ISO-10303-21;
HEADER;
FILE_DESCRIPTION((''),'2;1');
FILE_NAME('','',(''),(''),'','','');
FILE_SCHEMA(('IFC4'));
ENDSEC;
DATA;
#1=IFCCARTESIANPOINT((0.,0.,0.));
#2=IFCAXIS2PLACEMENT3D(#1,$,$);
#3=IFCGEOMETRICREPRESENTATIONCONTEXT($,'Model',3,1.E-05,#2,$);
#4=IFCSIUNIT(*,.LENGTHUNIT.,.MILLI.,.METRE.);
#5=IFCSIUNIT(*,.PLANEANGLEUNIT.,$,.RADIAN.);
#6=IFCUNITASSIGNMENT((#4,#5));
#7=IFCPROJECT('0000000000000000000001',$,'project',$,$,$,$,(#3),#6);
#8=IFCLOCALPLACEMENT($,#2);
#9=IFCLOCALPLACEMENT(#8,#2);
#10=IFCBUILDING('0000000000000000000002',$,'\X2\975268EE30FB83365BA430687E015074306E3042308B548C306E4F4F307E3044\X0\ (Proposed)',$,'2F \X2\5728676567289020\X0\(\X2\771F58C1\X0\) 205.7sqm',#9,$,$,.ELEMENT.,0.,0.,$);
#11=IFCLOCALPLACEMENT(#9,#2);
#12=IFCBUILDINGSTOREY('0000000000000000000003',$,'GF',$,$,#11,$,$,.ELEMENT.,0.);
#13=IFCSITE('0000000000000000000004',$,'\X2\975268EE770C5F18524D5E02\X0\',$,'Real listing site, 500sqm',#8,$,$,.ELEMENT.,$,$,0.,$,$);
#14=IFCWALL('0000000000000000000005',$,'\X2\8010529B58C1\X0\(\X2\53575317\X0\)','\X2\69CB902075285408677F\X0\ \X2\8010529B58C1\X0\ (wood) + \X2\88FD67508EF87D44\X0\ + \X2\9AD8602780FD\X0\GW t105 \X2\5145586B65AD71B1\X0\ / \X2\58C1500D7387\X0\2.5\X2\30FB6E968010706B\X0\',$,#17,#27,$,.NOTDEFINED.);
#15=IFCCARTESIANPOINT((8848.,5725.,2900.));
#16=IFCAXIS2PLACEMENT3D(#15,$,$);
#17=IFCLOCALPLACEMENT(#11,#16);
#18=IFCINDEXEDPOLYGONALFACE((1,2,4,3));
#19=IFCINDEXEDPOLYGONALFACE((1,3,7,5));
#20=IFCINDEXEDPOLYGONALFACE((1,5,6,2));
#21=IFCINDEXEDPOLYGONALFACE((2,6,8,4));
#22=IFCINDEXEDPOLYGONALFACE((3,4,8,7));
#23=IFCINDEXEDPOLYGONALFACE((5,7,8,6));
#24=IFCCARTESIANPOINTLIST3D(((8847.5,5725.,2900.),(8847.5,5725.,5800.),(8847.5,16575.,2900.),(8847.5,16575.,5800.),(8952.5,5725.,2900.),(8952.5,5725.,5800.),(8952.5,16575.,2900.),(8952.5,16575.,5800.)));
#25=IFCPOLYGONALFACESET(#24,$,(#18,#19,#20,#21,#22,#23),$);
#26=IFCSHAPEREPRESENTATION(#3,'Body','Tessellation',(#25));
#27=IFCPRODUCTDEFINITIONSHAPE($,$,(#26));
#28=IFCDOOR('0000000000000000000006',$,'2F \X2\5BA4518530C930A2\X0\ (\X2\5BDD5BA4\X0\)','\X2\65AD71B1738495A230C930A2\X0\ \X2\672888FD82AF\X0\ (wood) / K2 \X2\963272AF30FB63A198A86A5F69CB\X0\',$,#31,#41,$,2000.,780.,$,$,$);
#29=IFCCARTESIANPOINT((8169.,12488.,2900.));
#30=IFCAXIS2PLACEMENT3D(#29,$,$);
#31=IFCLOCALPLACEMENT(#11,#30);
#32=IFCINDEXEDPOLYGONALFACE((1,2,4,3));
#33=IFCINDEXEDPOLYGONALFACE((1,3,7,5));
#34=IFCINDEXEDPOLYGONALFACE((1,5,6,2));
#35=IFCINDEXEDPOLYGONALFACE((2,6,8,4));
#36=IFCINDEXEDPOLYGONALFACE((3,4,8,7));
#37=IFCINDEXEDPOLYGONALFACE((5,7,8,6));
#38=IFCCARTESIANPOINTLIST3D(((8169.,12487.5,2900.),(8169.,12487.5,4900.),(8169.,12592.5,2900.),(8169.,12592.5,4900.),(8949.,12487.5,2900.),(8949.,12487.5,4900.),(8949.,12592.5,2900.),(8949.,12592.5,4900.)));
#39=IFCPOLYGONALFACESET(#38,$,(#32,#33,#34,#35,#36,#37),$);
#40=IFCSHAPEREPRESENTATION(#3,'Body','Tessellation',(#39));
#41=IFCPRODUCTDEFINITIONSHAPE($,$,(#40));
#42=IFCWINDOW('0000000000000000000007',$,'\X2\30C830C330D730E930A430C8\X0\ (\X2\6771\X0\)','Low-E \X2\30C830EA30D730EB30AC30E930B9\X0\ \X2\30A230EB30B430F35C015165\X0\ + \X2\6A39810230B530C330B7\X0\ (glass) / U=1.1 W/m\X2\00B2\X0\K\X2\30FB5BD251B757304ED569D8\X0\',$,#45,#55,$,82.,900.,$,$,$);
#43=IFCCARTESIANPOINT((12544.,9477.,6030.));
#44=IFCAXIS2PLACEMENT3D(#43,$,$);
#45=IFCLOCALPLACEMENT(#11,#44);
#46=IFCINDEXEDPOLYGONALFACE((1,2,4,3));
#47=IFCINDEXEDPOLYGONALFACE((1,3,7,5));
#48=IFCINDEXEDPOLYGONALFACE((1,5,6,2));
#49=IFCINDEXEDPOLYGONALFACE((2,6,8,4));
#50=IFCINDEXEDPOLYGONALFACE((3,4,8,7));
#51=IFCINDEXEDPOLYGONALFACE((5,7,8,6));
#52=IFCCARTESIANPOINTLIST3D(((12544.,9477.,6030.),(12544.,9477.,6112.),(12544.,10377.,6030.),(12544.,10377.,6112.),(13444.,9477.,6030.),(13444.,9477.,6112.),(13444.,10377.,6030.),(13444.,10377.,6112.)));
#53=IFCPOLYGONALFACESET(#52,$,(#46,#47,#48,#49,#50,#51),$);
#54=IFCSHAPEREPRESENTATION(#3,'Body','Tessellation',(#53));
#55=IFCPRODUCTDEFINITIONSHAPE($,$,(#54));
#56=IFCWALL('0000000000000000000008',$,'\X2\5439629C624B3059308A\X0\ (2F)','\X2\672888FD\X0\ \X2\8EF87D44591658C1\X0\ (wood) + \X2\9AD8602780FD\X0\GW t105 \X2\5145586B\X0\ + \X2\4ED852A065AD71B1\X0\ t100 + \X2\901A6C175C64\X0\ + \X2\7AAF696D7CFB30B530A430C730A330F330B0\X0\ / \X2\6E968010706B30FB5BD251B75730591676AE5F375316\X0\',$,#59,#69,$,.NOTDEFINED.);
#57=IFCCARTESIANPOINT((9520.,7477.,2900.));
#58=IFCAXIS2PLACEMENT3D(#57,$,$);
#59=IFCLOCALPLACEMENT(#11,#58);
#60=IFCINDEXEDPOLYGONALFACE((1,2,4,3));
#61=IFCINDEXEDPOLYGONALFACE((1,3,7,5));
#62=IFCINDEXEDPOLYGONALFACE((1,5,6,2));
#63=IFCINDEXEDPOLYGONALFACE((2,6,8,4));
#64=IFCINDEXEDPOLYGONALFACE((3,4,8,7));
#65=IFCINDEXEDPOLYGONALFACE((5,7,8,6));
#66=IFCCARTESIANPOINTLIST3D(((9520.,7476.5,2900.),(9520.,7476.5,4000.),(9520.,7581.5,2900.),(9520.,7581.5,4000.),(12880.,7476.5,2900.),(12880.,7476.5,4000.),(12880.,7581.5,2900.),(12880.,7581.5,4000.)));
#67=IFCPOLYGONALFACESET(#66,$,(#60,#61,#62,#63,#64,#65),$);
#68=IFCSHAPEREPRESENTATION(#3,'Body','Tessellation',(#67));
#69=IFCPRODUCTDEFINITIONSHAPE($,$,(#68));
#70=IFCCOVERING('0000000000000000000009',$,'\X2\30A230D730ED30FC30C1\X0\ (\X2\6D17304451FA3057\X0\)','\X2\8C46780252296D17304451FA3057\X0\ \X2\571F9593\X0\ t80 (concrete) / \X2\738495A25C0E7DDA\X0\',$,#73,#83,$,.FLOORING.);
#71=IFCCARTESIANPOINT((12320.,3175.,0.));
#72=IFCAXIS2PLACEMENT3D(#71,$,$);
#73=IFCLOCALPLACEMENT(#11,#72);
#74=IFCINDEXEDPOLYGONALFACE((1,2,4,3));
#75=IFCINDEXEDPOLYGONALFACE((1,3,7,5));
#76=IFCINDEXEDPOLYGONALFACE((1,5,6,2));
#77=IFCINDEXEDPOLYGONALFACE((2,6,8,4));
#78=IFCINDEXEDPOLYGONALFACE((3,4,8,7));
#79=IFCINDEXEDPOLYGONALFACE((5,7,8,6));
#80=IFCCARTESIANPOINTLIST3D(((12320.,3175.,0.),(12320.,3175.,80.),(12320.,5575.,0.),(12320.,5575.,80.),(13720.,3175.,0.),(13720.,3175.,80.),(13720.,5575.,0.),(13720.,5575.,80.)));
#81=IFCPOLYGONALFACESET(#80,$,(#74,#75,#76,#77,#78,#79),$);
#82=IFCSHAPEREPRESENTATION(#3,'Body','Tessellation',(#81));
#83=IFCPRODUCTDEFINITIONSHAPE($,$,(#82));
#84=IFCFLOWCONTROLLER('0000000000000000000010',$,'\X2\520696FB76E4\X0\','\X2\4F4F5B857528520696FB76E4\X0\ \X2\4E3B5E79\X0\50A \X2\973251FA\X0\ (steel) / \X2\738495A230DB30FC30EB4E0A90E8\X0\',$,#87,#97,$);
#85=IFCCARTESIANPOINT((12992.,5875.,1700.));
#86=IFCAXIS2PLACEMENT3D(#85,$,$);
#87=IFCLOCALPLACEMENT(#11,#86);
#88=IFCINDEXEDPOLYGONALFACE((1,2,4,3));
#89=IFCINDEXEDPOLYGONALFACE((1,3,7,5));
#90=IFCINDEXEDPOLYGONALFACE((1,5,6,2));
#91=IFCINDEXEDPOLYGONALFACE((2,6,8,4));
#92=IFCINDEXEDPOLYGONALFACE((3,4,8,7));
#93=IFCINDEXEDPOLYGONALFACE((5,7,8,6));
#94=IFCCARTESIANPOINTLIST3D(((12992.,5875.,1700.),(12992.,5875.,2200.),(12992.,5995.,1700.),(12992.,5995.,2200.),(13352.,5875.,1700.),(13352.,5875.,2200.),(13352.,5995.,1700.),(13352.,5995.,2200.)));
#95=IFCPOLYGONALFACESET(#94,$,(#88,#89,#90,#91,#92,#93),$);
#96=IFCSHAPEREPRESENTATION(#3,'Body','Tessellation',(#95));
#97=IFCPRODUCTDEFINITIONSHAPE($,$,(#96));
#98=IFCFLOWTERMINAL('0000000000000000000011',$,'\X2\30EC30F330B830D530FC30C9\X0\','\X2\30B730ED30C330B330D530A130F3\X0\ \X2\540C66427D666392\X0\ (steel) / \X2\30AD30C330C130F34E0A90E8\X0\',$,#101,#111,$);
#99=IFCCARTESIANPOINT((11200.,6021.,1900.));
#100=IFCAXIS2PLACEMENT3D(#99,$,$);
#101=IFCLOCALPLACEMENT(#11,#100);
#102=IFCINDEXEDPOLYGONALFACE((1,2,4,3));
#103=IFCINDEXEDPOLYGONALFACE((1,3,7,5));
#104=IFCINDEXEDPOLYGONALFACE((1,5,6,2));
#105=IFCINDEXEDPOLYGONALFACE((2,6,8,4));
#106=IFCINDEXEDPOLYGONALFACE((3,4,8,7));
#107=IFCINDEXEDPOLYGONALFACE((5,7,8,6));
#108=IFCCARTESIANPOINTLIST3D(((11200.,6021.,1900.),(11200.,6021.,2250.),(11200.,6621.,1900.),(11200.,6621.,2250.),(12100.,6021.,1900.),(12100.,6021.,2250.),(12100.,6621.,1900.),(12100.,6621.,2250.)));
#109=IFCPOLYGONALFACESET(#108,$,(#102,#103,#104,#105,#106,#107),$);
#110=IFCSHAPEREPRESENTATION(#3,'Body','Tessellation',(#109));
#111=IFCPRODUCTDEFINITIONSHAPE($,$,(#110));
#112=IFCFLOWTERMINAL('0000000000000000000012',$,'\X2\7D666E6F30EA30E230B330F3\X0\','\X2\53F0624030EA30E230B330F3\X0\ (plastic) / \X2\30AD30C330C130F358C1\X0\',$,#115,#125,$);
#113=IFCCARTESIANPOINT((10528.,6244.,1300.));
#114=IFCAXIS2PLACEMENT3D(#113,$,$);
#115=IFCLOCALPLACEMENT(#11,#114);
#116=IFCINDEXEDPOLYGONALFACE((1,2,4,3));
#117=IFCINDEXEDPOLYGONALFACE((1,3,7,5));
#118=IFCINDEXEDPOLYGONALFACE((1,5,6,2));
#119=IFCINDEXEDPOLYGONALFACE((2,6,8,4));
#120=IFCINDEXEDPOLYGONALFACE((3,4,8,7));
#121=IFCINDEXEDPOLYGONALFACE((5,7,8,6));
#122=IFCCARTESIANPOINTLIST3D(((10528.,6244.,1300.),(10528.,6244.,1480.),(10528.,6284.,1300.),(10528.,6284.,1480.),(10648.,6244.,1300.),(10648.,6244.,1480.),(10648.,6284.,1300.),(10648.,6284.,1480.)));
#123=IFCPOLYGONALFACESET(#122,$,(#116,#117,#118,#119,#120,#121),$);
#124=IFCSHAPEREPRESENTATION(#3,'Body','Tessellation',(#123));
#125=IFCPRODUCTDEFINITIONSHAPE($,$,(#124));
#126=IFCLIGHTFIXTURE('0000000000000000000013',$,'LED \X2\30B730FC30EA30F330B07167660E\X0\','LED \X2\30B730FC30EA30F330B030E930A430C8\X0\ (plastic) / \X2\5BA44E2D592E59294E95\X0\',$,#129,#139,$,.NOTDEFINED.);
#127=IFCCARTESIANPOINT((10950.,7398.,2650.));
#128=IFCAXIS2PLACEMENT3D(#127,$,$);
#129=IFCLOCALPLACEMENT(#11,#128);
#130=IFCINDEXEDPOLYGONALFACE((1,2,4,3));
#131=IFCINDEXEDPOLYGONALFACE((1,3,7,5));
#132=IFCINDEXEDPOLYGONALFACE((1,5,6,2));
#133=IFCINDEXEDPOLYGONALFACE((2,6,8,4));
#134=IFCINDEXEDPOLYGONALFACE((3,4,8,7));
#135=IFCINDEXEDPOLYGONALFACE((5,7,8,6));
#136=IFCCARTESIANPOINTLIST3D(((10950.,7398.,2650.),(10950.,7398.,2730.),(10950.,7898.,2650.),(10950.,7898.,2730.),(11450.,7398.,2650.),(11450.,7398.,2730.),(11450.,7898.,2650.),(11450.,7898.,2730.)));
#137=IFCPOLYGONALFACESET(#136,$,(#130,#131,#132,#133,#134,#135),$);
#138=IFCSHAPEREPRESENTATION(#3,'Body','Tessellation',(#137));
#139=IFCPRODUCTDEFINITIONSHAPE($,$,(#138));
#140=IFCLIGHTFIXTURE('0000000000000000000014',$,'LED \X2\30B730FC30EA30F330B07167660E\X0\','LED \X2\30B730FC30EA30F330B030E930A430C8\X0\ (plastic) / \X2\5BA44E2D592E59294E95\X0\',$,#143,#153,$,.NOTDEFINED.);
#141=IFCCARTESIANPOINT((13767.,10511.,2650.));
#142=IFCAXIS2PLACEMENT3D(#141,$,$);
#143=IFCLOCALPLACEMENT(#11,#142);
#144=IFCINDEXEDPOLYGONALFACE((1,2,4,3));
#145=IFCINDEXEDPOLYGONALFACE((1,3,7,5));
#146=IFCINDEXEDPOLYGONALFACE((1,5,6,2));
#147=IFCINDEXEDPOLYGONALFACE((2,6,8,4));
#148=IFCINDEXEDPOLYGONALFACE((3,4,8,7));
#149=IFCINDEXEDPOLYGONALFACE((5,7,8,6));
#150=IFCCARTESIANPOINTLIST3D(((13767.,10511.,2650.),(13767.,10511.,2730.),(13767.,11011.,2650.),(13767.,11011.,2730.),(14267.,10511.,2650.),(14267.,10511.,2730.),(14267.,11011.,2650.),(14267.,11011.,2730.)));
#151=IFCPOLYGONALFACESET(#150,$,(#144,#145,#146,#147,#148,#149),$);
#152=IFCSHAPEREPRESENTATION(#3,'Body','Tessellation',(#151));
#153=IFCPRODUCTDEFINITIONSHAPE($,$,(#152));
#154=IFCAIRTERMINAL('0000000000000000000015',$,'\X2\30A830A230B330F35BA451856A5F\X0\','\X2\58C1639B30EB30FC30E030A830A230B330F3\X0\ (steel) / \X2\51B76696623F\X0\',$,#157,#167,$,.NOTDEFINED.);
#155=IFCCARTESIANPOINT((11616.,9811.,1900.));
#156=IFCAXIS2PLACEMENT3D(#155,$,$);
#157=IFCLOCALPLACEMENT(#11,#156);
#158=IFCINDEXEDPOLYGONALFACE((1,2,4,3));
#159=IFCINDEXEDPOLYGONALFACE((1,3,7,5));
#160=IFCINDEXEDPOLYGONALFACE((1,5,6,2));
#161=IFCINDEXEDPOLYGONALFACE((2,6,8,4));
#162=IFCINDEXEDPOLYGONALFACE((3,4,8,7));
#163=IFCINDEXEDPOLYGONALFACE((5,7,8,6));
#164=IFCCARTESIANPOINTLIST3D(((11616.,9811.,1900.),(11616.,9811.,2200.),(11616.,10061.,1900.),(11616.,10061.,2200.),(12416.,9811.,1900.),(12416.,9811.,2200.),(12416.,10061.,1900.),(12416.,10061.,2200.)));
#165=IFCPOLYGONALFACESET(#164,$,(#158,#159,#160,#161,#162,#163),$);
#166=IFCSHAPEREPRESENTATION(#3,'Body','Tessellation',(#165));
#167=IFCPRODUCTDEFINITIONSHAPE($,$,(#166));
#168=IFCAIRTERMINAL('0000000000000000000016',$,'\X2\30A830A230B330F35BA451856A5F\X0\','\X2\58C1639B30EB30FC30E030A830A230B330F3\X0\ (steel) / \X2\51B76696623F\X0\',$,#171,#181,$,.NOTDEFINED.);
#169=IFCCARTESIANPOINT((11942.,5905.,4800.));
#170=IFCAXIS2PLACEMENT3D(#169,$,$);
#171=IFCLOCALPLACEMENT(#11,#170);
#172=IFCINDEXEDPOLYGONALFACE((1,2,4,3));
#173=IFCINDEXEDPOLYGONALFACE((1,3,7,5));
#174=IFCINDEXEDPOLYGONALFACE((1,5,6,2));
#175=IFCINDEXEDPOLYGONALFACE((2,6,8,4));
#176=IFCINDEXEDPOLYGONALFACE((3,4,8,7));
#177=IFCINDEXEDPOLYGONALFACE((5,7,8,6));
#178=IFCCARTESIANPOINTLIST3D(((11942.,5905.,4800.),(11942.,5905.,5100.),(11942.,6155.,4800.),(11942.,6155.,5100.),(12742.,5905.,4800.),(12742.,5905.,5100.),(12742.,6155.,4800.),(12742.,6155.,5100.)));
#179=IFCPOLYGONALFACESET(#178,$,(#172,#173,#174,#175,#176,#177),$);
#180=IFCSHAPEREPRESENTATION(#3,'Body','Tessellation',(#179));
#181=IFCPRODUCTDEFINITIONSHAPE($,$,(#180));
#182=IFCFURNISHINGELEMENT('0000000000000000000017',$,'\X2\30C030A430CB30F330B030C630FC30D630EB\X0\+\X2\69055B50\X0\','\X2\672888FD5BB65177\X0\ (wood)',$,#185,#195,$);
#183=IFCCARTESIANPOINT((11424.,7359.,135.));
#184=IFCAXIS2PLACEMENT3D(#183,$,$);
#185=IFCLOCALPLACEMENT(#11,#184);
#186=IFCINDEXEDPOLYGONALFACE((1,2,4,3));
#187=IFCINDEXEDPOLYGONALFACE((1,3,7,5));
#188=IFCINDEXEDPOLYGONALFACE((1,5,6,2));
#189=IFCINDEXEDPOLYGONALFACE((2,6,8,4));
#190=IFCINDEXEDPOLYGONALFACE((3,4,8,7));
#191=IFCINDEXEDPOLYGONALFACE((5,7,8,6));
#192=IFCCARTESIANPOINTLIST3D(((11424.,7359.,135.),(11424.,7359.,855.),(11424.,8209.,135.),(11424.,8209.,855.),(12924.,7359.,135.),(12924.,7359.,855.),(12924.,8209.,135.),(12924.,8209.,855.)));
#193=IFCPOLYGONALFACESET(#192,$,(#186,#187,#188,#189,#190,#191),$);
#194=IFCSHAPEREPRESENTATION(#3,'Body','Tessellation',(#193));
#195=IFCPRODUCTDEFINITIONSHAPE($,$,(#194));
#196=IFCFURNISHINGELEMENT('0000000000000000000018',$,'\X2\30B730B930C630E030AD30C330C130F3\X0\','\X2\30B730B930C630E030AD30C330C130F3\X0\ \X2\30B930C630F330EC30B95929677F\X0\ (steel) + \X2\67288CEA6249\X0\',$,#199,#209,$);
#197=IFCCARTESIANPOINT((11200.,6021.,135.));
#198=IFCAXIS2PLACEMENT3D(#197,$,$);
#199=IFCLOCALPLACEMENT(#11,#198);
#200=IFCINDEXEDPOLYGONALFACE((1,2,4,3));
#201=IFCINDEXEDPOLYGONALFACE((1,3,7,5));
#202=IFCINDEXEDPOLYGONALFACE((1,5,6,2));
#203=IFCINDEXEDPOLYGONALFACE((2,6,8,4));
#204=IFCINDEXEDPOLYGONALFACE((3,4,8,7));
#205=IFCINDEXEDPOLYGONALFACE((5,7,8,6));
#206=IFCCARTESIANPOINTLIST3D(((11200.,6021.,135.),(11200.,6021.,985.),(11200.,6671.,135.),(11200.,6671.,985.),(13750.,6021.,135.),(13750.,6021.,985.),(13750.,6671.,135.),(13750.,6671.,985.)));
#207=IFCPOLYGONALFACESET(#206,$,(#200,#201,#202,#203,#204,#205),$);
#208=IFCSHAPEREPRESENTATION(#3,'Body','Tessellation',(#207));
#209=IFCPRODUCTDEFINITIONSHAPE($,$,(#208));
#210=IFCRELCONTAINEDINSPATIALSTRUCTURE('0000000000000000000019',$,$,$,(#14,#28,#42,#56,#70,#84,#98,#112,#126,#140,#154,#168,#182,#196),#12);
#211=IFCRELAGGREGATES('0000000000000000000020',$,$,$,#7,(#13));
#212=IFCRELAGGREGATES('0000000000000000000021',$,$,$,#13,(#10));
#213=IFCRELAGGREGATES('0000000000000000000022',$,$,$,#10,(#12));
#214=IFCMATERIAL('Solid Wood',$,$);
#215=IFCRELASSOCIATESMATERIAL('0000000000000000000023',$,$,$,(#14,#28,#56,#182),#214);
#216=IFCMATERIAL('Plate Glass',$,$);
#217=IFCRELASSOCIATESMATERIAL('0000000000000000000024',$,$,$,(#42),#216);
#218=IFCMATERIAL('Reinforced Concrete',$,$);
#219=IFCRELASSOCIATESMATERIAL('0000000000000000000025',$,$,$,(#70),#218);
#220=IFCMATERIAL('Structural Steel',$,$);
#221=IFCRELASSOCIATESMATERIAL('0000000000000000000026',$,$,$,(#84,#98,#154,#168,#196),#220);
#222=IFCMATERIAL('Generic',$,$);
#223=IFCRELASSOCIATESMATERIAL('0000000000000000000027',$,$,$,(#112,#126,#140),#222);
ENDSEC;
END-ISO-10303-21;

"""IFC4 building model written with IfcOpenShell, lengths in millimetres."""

from ifc_helpers import new_model, si_unit, frame, frame_2d, origin, place, context, project, spatial, rectangle, extrude, material, element, fill, save


model = new_model("IFC4")

# Units and contexts
model_context = context("Model", 3, precision=1e-05, world=origin())
ifc_project = project(units=[si_unit("LENGTHUNIT", "METRE", prefix="MILLI"), si_unit("PLANEANGLEUNIT", "RADIAN")], contexts=[model_context])

# Site, building, storey
site_placement = place(None, origin())
site = spatial("IfcSite", under=ifc_project, at=site_placement, Name="青森県弘前市", ObjectType="Real listing site, 500sqm", CompositionType="ELEMENT", RefElevation=0.0)
building_placement = place(site_placement, origin())
building = spatial("IfcBuilding", under=site, at=building_placement, Name="青森・茶室と縁側のある和の住まい (Proposed)", ObjectType="2F 在来木造(真壁) 205.7sqm", CompositionType="ELEMENT", ElevationOfRefHeight=0.0, ElevationOfTerrain=0.0)
storey_placement = place(building_placement, origin())
storey = spatial("IfcBuildingStorey", under=building, at=storey_placement, Name="GF", CompositionType="ELEMENT", Elevation=0.0)

# Shared definitions
ifc_material_1 = material(Name="Solid Wood")

# Wall, opening, door
wall_1_placement = place(storey_placement, frame((8848.0, 5725.0, 2900.0)))
wall_1 = element("IfcWall", 1, at=wall_1_placement, inside=storey, material=ifc_material_1, Name="耐力壁(南北)", Description="構造用合板 耐力壁 (wood) + 製材軸組 + 高性能GW t105 充填断熱 / 壁倍率2.5・準耐火", PredefinedType="NOTDEFINED", context=model_context, shape_type="SweptSolid", body=[
    extrude(rectangle(XDim=105.0, YDim=10850.0, at=frame_2d((52.0, 5425.0))), frame((8848.0, 5725.0, 2900.0)), (0.0, 0.0, 1.0), 2900.0),
])
opening_1_placement = place(storey_placement, frame((8169.0, 12488.0, 2900.0)))
opening_1 = element("IfcOpeningElement", 2, at=opening_1_placement, cuts=wall_1, PredefinedType="NOTDEFINED", context=model_context, shape_type="SweptSolid", body=[
    extrude(rectangle(XDim=780.0, YDim=105.0, at=frame_2d((390.0, 52.0))), frame((8169.0, 12488.0, 2900.0)), (0.0, 0.0, 1.0), 2000.0),
])
door_1_placement = place(storey_placement, frame((8169.0, 12488.0, 2900.0)))
door_1 = element("IfcDoor", 3, at=door_1_placement, inside=storey, material=ifc_material_1, Name="2F 室内ドア (寝室)", Description="断熱玄関ドア 木製芯 (wood) / K2 防犯・採風機構", OverallHeight=2000.0, OverallWidth=780.0, context=model_context, shape_type="SweptSolid", body=[
    extrude(rectangle(XDim=780.0, YDim=105.0, at=frame_2d((390.0, 52.0))), frame((8169.0, 12488.0, 2900.0)), (0.0, 0.0, 1.0), 2000.0),
])
fill(opening_1, door_1)

# Window
ifc_material_2 = material(Name="Plate Glass")
window_placement = place(storey_placement, frame((12544.0, 9477.0, 6030.0)))
element("IfcWindow", 4, at=window_placement, inside=storey, material=ifc_material_2, Name="トップライト (東)", Description="Low-E トリプルガラス アルゴン封入 + 樹脂サッシ (glass) / U=1.1 W/m²K・寒冷地仕様", OverallHeight=82.0, OverallWidth=900.0, context=model_context, shape_type="SweptSolid", body=[
    extrude(rectangle(XDim=900.0, YDim=900.0, at=frame_2d((450.0, 450.0))), frame((12544.0, 9477.0, 6030.0)), (0.0, 0.0, 1.0), 82.0),
])

# Wall
wall_2_placement = place(storey_placement, frame((9520.0, 7477.0, 2900.0)))
element("IfcWall", 5, at=wall_2_placement, inside=storey, material=ifc_material_1, Name="吹抜手すり (2F)", Description="木製 軸組外壁 (wood) + 高性能GW t105 充填 + 付加断熱 t100 + 通気層 + 窯業系サイディング / 準耐火・寒冷地外皮強化", PredefinedType="NOTDEFINED", context=model_context, shape_type="SweptSolid", body=[
    extrude(rectangle(XDim=3360.0, YDim=105.0, at=frame_2d((1680.0, 52.0))), frame((9520.0, 7477.0, 2900.0)), (0.0, 0.0, 1.0), 1100.0),
])

# Covering
ifc_material_3 = material(Name="Reinforced Concrete")
covering_placement = place(storey_placement, frame((12320.0, 3175.0, 0.0)))
element("IfcCovering", 6, at=covering_placement, inside=storey, material=ifc_material_3, Name="アプローチ (洗い出し)", Description="豆砂利洗い出し 土間 t80 (concrete) / 玄関導線", PredefinedType="FLOORING", context=model_context, shape_type="SweptSolid", body=[
    extrude(rectangle(XDim=1400.0, YDim=2400.0, at=frame_2d((700.0, 1200.0))), frame((12320.0, 3175.0, 0.0)), (0.0, 0.0, 1.0), 80.0),
])

# Flow controller
ifc_material_4 = material(Name="Structural Steel")
flow_controller_placement = place(storey_placement, frame((12992.0, 5875.0, 1700.0)))
element("IfcFlowController", 7, at=flow_controller_placement, inside=storey, material=ifc_material_4, Name="分電盤", Description="住宅用分電盤 主幹50A 露出 (steel) / 玄関ホール上部", context=model_context, shape_type="SweptSolid", body=[
    extrude(rectangle(XDim=360.0, YDim=120.0, at=frame_2d((180.0, 60.0))), frame((12992.0, 5875.0, 1700.0)), (0.0, 0.0, 1.0), 500.0),
])

# Flow terminals
flow_terminal_1_placement = place(storey_placement, frame((11200.0, 6021.0, 1900.0)))
element("IfcFlowTerminal", 8, at=flow_terminal_1_placement, inside=storey, material=ifc_material_4, Name="レンジフード", Description="シロッコファン 同時給排 (steel) / キッチン上部", context=model_context, shape_type="SweptSolid", body=[
    extrude(rectangle(XDim=900.0, YDim=600.0, at=frame_2d((450.0, 300.0))), frame((11200.0, 6021.0, 1900.0)), (0.0, 0.0, 1.0), 350.0),
])
ifc_material_5 = material(Name="Generic")
flow_terminal_2_placement = place(storey_placement, frame((10528.0, 6244.0, 1300.0)))
element("IfcFlowTerminal", 9, at=flow_terminal_2_placement, inside=storey, material=ifc_material_5, Name="給湯リモコン", Description="台所リモコン (plastic) / キッチン壁", context=model_context, shape_type="SweptSolid", body=[
    extrude(rectangle(XDim=120.0, YDim=40.0, at=frame_2d((60.0, 20.0))), frame((10528.0, 6244.0, 1300.0)), (0.0, 0.0, 1.0), 180.0),
])

# Light fixtures
light_fixture_1_placement = place(storey_placement, frame((10950.0, 7398.0, 2650.0)))
element("IfcLightFixture", 10, at=light_fixture_1_placement, inside=storey, material=ifc_material_5, Name="LED シーリング照明", Description="LED シーリングライト (plastic) / 室中央天井", PredefinedType="NOTDEFINED", context=model_context, shape_type="SweptSolid", body=[
    extrude(rectangle(XDim=500.0, YDim=500.0, at=frame_2d((250.0, 250.0))), frame((10950.0, 7398.0, 2650.0)), (0.0, 0.0, 1.0), 80.0),
])
light_fixture_2_placement = place(storey_placement, frame((13767.0, 10511.0, 2650.0)))
element("IfcLightFixture", 11, at=light_fixture_2_placement, inside=storey, material=ifc_material_5, Name="LED シーリング照明", Description="LED シーリングライト (plastic) / 室中央天井", PredefinedType="NOTDEFINED", context=model_context, shape_type="SweptSolid", body=[
    extrude(rectangle(XDim=500.0, YDim=500.0, at=frame_2d((250.0, 250.0))), frame((13767.0, 10511.0, 2650.0)), (0.0, 0.0, 1.0), 80.0),
])

# Air terminals
air_terminal_1_placement = place(storey_placement, frame((11616.0, 9811.0, 1900.0)))
element("IfcAirTerminal", 12, at=air_terminal_1_placement, inside=storey, material=ifc_material_4, Name="エアコン室内機", Description="壁掛ルームエアコン (steel) / 冷暖房", PredefinedType="NOTDEFINED", context=model_context, shape_type="SweptSolid", body=[
    extrude(rectangle(XDim=800.0, YDim=250.0, at=frame_2d((400.0, 125.0))), frame((11616.0, 9811.0, 1900.0)), (0.0, 0.0, 1.0), 300.0),
])
air_terminal_2_placement = place(storey_placement, frame((11942.0, 5905.0, 4800.0)))
element("IfcAirTerminal", 13, at=air_terminal_2_placement, inside=storey, material=ifc_material_4, Name="エアコン室内機", Description="壁掛ルームエアコン (steel) / 冷暖房", PredefinedType="NOTDEFINED", context=model_context, shape_type="SweptSolid", body=[
    extrude(rectangle(XDim=800.0, YDim=250.0, at=frame_2d((400.0, 125.0))), frame((11942.0, 5905.0, 4800.0)), (0.0, 0.0, 1.0), 300.0),
])

# Furnishing elements
furnishing_1_placement = place(storey_placement, frame((11424.0, 7359.0, 135.0)))
element("IfcFurnishingElement", 14, at=furnishing_1_placement, inside=storey, material=ifc_material_1, Name="ダイニングテーブル+椅子", Description="木製家具 (wood)", context=model_context, shape_type="SweptSolid", body=[
    extrude(rectangle(XDim=1500.0, YDim=850.0, at=frame_2d((750.0, 425.0))), frame((11424.0, 7359.0, 135.0)), (0.0, 0.0, 1.0), 720.0),
])
furnishing_2_placement = place(storey_placement, frame((11200.0, 6021.0, 135.0)))
element("IfcFurnishingElement", 15, at=furnishing_2_placement, inside=storey, material=ifc_material_4, Name="システムキッチン", Description="システムキッチン ステンレス天板 (steel) + 木質扉", context=model_context, shape_type="SweptSolid", body=[
    extrude(rectangle(XDim=2550.0, YDim=650.0, at=frame_2d((1275.0, 325.0))), frame((11200.0, 6021.0, 135.0)), (0.0, 0.0, 1.0), 850.0),
])

save(model, "model.ifc")
